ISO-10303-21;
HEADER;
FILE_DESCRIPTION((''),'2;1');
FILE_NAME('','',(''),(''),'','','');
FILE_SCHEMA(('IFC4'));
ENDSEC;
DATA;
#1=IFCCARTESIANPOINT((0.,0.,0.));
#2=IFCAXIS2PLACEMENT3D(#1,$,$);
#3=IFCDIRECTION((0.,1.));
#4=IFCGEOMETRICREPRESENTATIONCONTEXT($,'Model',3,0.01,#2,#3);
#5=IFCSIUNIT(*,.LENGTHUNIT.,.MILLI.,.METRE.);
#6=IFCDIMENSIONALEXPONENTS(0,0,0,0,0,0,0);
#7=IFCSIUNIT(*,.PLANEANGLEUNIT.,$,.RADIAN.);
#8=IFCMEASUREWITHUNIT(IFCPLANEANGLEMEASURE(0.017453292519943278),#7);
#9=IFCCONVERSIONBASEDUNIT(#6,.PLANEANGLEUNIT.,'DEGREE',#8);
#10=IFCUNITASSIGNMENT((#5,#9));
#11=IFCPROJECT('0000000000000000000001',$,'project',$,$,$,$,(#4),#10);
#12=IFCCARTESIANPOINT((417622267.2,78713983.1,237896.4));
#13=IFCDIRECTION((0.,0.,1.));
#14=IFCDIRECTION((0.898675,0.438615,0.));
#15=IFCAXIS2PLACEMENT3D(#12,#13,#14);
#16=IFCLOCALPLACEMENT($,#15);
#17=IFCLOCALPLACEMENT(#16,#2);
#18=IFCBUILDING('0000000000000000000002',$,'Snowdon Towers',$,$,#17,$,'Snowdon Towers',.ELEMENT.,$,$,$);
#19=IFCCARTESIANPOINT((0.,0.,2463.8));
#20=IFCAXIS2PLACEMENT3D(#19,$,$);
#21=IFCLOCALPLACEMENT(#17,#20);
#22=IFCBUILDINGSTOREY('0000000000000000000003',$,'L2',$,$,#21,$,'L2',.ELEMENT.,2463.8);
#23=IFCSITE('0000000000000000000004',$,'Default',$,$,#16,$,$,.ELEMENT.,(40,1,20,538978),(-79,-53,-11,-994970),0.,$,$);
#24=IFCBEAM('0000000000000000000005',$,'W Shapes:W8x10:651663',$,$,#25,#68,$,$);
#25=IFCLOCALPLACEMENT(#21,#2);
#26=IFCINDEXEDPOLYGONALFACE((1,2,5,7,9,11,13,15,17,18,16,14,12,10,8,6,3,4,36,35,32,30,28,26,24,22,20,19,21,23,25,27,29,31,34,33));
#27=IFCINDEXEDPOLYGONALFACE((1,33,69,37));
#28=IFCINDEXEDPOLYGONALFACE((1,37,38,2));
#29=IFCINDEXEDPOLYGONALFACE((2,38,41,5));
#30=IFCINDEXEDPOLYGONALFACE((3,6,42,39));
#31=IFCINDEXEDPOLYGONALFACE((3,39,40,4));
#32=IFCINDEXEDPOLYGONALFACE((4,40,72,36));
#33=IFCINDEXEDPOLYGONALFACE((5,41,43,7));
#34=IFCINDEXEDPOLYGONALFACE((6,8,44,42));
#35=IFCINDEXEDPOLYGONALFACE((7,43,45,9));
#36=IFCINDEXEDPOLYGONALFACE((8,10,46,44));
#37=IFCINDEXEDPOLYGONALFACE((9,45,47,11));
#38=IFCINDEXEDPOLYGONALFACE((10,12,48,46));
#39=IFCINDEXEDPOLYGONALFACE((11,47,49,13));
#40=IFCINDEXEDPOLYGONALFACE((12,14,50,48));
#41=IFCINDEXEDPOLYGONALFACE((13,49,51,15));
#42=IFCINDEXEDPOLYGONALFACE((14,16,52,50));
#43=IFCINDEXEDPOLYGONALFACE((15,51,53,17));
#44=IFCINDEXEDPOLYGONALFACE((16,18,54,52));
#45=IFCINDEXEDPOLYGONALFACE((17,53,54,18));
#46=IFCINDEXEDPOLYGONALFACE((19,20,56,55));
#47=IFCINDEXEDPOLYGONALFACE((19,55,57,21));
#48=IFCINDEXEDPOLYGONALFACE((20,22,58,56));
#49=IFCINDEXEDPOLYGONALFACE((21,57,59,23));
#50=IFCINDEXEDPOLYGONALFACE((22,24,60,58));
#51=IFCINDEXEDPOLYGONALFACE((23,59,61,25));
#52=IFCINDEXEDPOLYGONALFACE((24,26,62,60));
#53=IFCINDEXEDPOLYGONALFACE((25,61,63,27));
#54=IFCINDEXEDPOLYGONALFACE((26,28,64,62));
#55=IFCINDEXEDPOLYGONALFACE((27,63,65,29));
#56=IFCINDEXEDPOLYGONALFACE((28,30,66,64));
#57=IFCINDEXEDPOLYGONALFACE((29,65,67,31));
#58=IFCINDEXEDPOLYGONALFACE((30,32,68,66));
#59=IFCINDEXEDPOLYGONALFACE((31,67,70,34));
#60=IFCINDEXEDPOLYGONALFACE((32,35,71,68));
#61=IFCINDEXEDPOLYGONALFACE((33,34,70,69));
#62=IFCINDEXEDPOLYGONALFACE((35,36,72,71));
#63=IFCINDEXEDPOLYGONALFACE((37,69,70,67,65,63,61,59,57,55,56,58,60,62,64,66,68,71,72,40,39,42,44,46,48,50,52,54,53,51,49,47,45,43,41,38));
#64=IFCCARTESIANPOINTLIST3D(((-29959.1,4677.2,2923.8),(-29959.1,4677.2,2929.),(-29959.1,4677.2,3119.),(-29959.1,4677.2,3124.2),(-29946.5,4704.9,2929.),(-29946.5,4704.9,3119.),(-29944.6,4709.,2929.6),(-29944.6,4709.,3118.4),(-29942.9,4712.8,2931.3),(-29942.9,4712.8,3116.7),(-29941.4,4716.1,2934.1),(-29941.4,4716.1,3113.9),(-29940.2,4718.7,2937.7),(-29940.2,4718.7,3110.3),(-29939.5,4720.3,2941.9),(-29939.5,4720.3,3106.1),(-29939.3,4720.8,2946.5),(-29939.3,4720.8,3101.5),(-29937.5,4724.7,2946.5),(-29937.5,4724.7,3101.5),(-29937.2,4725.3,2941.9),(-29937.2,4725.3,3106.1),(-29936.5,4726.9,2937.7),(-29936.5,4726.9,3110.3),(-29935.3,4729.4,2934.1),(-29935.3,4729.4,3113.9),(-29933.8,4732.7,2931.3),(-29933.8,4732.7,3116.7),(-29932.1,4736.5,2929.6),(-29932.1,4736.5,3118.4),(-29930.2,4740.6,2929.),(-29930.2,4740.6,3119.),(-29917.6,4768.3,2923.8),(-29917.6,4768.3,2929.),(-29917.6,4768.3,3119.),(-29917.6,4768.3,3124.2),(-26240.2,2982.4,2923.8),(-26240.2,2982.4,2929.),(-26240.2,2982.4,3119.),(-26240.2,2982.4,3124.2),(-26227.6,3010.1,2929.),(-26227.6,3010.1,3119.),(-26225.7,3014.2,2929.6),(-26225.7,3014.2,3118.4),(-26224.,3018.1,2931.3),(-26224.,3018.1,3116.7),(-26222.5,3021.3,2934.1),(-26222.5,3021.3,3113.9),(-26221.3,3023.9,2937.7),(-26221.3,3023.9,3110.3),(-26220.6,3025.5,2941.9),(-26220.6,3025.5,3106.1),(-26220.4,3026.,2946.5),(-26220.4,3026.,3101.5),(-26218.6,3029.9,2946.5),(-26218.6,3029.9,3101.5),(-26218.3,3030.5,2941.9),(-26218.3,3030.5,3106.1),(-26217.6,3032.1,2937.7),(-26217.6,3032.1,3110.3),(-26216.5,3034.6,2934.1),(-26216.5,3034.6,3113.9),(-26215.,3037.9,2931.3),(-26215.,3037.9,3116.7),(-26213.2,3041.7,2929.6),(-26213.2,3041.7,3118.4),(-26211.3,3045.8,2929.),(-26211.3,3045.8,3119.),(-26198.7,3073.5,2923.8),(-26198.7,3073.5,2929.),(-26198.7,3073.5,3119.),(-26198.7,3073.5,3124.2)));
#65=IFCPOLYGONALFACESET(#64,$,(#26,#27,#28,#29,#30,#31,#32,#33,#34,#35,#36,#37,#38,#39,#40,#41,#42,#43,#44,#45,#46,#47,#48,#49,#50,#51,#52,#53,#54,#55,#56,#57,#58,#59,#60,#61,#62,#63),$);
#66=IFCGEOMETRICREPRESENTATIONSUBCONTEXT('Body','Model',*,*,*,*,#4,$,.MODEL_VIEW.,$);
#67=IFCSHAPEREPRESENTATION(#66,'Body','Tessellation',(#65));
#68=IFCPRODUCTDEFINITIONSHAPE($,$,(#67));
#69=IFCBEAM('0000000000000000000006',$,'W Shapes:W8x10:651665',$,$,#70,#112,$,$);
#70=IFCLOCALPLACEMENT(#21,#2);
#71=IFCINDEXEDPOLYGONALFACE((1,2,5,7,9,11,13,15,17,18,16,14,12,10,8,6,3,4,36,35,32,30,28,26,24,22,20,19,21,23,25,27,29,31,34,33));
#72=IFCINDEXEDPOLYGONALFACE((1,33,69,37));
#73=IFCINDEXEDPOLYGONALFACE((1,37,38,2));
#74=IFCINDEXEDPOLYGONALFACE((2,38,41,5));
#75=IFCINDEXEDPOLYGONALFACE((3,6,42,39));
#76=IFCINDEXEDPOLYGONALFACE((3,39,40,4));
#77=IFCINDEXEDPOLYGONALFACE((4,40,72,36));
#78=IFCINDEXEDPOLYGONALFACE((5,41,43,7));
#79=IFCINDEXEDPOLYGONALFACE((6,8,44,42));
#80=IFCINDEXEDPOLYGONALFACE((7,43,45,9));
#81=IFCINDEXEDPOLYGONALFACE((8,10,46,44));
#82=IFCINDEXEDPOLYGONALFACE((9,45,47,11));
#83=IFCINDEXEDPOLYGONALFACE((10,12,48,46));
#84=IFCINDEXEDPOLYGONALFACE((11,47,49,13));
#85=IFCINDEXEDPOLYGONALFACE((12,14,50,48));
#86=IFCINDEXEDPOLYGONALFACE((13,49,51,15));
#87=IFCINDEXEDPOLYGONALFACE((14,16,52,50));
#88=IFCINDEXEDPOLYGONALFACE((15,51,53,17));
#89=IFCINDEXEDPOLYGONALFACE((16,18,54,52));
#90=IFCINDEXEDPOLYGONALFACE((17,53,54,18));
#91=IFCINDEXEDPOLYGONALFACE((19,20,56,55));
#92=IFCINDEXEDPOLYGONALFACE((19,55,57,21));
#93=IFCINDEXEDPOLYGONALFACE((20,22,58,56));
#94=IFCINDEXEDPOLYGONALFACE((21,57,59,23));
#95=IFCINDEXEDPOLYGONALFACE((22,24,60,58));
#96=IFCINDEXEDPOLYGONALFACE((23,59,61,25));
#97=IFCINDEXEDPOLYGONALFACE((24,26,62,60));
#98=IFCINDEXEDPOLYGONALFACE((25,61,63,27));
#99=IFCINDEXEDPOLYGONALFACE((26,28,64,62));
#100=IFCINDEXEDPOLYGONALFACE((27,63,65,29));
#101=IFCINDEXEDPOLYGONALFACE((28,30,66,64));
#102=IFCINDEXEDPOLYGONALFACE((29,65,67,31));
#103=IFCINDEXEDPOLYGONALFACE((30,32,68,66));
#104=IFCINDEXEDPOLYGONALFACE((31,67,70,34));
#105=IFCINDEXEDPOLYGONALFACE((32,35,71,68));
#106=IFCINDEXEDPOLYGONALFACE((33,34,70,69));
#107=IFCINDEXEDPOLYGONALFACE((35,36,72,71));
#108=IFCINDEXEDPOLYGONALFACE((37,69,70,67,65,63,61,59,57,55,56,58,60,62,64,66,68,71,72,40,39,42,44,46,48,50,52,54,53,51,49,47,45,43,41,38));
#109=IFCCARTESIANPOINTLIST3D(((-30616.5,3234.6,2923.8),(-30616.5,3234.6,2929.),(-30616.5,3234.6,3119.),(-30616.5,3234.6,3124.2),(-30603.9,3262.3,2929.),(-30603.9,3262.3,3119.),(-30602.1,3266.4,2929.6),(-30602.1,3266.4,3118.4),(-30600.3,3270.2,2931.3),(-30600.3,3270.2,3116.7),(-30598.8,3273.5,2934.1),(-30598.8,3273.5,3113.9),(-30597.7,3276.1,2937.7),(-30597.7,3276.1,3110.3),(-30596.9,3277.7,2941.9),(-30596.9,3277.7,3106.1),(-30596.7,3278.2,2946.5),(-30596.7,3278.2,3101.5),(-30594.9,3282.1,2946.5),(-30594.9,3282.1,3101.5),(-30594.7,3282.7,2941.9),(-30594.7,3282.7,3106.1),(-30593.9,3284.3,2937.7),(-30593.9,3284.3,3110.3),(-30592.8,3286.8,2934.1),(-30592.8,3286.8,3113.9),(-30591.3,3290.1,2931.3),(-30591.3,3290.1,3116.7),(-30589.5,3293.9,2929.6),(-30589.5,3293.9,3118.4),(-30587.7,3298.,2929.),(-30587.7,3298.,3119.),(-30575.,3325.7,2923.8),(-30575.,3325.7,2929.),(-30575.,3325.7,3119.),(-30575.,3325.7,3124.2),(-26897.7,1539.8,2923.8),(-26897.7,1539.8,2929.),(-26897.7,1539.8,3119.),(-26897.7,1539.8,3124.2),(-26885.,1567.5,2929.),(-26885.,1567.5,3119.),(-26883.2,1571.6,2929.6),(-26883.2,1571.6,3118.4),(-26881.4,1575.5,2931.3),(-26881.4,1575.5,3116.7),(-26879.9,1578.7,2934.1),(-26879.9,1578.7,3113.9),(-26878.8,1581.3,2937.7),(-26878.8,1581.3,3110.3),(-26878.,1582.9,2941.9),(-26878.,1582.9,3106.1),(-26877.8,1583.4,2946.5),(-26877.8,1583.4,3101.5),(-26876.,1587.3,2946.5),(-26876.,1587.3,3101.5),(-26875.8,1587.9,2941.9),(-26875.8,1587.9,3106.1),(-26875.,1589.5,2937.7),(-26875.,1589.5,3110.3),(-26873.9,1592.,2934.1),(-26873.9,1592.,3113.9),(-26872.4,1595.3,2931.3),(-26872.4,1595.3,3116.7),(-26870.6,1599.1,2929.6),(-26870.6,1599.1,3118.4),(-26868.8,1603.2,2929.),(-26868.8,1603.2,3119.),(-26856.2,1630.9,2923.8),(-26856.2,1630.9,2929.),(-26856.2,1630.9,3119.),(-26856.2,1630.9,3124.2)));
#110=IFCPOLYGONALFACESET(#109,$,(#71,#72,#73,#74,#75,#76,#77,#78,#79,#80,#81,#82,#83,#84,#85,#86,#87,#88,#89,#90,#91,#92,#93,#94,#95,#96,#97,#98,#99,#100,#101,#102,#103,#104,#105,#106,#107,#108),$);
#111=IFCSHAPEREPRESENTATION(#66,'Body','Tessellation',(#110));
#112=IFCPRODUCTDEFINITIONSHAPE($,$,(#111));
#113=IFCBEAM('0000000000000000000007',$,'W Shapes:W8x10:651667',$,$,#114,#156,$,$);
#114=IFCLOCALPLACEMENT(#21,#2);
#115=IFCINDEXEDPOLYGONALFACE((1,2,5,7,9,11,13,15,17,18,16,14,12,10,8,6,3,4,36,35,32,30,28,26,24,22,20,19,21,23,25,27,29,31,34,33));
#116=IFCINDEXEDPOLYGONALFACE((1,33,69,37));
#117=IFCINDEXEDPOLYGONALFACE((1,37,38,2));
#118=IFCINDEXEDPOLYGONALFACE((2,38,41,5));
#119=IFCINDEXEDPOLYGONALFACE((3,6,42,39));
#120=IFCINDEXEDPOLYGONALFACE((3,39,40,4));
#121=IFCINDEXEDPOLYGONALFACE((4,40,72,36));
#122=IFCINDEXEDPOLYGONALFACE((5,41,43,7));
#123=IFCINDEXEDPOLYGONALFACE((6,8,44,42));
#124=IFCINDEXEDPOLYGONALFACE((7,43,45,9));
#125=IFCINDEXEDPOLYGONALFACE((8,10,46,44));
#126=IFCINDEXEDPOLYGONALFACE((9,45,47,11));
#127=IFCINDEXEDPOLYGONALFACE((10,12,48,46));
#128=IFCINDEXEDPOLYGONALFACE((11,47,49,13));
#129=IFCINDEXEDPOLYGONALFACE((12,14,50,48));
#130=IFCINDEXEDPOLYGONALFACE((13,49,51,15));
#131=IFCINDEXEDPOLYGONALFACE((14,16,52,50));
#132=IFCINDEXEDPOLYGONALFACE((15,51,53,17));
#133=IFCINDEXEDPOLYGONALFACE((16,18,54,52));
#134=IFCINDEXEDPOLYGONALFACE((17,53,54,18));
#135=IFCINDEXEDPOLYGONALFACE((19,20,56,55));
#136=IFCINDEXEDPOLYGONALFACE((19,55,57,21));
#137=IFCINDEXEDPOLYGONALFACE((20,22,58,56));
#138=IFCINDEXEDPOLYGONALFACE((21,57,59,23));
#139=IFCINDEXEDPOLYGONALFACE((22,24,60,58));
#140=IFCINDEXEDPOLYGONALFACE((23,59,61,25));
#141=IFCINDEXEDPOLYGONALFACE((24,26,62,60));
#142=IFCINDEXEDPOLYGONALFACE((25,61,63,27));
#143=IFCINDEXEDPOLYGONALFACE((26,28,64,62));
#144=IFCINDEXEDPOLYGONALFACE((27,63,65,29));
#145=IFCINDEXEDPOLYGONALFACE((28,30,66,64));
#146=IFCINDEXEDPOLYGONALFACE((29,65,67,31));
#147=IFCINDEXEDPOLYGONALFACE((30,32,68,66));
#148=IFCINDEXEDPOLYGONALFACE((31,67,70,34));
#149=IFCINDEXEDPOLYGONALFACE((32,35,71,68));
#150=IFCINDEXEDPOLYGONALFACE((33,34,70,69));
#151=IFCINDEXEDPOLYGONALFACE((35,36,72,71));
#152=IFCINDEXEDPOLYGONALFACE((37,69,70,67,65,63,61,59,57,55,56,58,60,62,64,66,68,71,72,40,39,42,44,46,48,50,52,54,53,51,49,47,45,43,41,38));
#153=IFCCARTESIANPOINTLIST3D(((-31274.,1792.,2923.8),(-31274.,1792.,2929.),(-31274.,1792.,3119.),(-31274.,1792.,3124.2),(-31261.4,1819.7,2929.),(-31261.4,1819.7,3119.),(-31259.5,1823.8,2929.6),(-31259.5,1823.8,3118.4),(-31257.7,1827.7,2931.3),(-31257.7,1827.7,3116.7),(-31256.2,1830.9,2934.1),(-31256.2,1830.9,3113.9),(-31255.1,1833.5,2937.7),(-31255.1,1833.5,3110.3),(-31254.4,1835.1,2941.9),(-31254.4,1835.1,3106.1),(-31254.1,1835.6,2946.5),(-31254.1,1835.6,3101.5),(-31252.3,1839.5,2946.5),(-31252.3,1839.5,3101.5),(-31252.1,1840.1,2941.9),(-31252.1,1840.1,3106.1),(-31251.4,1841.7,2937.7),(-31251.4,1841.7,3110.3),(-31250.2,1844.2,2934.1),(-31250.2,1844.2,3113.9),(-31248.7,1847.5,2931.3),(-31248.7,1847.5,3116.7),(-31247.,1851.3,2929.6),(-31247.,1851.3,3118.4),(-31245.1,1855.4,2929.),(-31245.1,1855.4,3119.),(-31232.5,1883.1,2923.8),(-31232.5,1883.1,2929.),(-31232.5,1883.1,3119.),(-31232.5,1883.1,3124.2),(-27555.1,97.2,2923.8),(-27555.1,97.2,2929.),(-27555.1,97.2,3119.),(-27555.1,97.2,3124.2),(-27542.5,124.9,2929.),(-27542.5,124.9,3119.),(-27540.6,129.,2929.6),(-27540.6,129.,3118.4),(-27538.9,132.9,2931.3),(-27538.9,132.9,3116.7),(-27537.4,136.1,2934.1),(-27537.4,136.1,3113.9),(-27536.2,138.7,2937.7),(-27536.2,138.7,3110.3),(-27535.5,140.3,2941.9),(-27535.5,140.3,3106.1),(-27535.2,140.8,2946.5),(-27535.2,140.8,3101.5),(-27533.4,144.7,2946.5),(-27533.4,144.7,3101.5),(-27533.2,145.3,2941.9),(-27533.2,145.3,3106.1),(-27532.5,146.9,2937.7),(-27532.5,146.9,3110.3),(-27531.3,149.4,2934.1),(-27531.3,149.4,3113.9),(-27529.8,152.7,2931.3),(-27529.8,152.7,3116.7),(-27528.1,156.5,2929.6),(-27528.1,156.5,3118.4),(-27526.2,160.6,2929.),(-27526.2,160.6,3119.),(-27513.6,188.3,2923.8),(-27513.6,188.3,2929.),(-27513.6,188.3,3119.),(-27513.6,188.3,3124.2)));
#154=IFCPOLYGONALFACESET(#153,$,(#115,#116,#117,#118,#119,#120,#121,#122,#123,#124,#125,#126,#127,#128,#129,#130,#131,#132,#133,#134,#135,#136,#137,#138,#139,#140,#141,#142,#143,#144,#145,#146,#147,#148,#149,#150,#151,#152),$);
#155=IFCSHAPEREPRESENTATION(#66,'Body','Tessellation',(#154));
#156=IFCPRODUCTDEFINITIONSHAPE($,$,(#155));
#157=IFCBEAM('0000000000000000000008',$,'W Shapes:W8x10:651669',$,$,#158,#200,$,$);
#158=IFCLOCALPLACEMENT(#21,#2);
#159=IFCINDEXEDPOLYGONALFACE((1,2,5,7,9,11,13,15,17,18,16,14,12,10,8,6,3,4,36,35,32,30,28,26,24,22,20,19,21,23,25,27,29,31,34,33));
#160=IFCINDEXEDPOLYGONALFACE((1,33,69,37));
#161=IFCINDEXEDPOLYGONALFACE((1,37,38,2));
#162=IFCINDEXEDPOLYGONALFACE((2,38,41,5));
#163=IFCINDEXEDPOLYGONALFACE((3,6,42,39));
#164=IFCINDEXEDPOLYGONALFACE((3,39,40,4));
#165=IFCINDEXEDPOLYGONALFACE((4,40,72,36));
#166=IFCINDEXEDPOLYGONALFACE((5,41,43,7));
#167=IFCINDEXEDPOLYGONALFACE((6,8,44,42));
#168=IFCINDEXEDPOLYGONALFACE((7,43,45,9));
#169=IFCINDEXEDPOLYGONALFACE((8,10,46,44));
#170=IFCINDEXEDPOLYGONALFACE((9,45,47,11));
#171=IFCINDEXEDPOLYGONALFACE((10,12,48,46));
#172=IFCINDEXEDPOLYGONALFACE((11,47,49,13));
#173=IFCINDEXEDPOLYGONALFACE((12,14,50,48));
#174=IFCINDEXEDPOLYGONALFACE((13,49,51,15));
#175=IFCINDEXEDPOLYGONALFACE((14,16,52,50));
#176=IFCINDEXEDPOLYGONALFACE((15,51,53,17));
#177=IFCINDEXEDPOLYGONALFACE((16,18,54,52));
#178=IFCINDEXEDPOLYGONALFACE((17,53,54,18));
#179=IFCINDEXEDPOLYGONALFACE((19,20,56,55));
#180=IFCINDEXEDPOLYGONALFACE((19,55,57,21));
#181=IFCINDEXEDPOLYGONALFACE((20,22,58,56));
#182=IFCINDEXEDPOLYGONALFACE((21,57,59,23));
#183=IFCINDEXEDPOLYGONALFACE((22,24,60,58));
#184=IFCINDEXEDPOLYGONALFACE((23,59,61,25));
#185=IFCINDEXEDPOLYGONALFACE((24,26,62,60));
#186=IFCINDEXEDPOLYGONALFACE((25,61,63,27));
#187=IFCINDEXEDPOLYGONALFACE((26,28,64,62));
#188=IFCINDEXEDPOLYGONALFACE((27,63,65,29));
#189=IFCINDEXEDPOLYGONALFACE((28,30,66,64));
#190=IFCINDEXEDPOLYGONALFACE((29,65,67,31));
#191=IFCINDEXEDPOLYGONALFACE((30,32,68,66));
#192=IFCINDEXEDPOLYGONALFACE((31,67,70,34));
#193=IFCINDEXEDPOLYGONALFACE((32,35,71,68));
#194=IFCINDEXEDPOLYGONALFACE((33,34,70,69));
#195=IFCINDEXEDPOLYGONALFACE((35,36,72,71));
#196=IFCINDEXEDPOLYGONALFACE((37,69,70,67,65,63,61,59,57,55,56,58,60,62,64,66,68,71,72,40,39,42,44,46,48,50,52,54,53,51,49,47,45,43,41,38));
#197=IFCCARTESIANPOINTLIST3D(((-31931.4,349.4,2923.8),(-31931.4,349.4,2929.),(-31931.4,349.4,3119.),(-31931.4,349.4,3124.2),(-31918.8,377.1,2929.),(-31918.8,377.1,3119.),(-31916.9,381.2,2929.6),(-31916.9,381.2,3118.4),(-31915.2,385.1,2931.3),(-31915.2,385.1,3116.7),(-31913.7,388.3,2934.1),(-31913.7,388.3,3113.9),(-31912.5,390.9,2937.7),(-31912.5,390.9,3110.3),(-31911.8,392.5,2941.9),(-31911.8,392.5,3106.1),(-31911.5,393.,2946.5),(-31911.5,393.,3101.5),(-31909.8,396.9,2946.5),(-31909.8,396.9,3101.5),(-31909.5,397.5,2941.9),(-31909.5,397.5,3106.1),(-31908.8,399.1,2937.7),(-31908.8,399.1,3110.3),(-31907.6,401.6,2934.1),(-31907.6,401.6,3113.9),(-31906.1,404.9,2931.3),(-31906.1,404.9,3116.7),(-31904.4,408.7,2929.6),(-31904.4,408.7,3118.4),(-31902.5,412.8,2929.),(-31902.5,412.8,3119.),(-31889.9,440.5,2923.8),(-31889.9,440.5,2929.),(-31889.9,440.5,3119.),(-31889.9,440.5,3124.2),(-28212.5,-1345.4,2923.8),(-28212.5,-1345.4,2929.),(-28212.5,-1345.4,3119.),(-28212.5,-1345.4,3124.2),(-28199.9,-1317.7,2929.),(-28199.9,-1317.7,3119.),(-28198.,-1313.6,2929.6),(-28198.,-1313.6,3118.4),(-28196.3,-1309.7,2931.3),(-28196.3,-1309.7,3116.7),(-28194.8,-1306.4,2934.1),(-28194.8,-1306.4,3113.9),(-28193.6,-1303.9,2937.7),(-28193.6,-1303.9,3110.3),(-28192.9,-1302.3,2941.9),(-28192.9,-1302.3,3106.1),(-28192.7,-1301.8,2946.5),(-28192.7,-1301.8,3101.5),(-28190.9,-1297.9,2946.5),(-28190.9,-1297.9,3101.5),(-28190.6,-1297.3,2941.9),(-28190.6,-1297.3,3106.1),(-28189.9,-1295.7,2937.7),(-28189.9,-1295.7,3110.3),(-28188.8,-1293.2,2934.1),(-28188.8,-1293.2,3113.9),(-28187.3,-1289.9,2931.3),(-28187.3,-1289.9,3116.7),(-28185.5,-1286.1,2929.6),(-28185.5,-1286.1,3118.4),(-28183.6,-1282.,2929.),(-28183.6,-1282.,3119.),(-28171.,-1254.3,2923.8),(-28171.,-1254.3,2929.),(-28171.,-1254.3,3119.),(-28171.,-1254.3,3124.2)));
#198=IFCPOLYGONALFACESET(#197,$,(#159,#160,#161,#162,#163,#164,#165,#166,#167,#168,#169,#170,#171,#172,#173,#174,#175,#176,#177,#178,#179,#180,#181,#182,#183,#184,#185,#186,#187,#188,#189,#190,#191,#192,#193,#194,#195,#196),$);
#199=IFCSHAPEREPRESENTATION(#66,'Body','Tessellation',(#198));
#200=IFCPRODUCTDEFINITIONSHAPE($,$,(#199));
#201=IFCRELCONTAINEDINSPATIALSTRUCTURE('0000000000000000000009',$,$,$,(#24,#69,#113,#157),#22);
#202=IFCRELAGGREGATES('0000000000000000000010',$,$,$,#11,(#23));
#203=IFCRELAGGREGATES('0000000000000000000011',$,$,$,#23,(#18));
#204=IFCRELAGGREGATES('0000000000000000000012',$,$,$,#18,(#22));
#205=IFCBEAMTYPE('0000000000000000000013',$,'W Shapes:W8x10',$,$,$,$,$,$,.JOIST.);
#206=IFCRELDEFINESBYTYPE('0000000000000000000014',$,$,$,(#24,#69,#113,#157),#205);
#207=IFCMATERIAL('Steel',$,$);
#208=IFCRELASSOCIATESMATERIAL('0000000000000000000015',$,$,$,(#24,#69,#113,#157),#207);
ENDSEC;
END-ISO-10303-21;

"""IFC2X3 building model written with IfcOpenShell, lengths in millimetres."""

from ifc_helpers import new_model, entity, si_unit, converted_unit, direction, frame, frame_2d, origin, place, context, subcontext, project, spatial, i_section, extrude, material, type_object, element, save


model = new_model("IFC2X3")

# Units and contexts
model_context = context("Model", 3, precision=0.01, world=origin(), true_north=direction((0.0, 1.0)))
body_context = subcontext(model_context, "Body", "Model", "MODEL_VIEW")
ifc_project = project(units=[si_unit("LENGTHUNIT", "METRE", prefix="MILLI"), converted_unit("PLANEANGLEUNIT", "DEGREE", entity("IfcPlaneAngleMeasure", 0.017453292519943278), si_unit("PLANEANGLEUNIT", "RADIAN"), dimensions=[0, 0, 0, 0, 0, 0, 0])], contexts=[model_context])

# Site, building, storey
site_placement = place(None, frame((417622267.2, 78713983.1, 237896.4), z_axis=(0.0, 0.0, 1.0), x_axis=(0.898675, 0.438615, 0.0)))
site = spatial("IfcSite", under=ifc_project, at=site_placement, Name="Default", CompositionType="ELEMENT", RefLatitude=(40, 1, 20, 538978), RefLongitude=(-79, -53, -11, -994970), RefElevation=0.0)
building_placement = place(site_placement, origin())
building = spatial("IfcBuilding", under=site, at=building_placement, Name="Snowdon Towers", LongName="Snowdon Towers", CompositionType="ELEMENT")
storey_placement = place(building_placement, frame((0.0, 0.0, 2463.8)))
storey = spatial("IfcBuildingStorey", under=building, at=storey_placement, Name="L2", LongName="L2", CompositionType="ELEMENT", Elevation=2463.8)

# Beams
ifc_material = material(Name="Steel")
beam_type_1 = type_object("IfcBeamType", Name="W Shapes:W8x10", PredefinedType="JOIST")
beam_1_placement = place(storey_placement, frame((-30066.6, 4781.2, 3124.2), z_axis=(0.0, 0.0, 1.0), x_axis=(0.909961, -0.414693, 0.0)))
element("IfcBeam", 1, at=beam_1_placement, inside=storey, type_object=beam_type_1, material=ifc_material, Name="W Shapes:W8x10:651663", context=body_context, shape_type="SweptSolid", body=[
    extrude(i_section(OverallWidth=100.1, OverallDepth=200.4, WebThickness=4.3, FlangeThickness=5.2, FilletRadius=17.5, at=frame_2d((0.0, 0.0), x_axis=(0.0, 1.0))), frame((141.0, 0.0, -100.2), z_axis=(1.0, 0.0, 0.0), x_axis=(0.0, 0.0, -1.0)), (0.0, 0.0, 1.0), 4086.9),
])
beam_2_placement = place(storey_placement, frame((-30724.1, 3338.6, 3124.2), z_axis=(0.0, 0.0, 1.0), x_axis=(0.909961, -0.414693, 0.0)))
element("IfcBeam", 2, at=beam_2_placement, inside=storey, type_object=beam_type_1, material=ifc_material, Name="W Shapes:W8x10:651665", context=body_context, shape_type="SweptSolid", body=[
    extrude(i_section(OverallWidth=100.1, OverallDepth=200.4, WebThickness=4.3, FlangeThickness=5.2, FilletRadius=17.5, at=frame_2d((0.0, 0.0), x_axis=(0.0, 1.0))), frame((141.0, 0.0, -100.2), z_axis=(1.0, 0.0, 0.0), x_axis=(0.0, 0.0, -1.0)), (0.0, 0.0, 1.0), 4086.9),
])
beam_3_placement = place(storey_placement, frame((-31381.5, 1896.0, 3124.2), z_axis=(0.0, 0.0, 1.0), x_axis=(0.909961, -0.414693, 0.0)))
element("IfcBeam", 3, at=beam_3_placement, inside=storey, type_object=beam_type_1, material=ifc_material, Name="W Shapes:W8x10:651667", context=body_context, shape_type="SweptSolid", body=[
    extrude(i_section(OverallWidth=100.1, OverallDepth=200.4, WebThickness=4.3, FlangeThickness=5.2, FilletRadius=17.5, at=frame_2d((0.0, 0.0), x_axis=(0.0, 1.0))), frame((141.0, 0.0, -100.2), z_axis=(1.0, 0.0, 0.0), x_axis=(0.0, 0.0, -1.0)), (0.0, 0.0, 1.0), 4086.9),
])
beam_4_placement = place(storey_placement, frame((-32038.9, 453.4, 3124.2), z_axis=(0.0, 0.0, 1.0), x_axis=(0.909961, -0.414693, 0.0)))
element("IfcBeam", 4, at=beam_4_placement, inside=storey, type_object=beam_type_1, material=ifc_material, Name="W Shapes:W8x10:651669", context=body_context, shape_type="SweptSolid", body=[
    extrude(i_section(OverallWidth=100.1, OverallDepth=200.4, WebThickness=4.3, FlangeThickness=5.2, FilletRadius=17.5, at=frame_2d((0.0, 0.0), x_axis=(0.0, 1.0))), frame((141.0, 0.0, -100.2), z_axis=(1.0, 0.0, 0.0), x_axis=(0.0, 0.0, -1.0)), (0.0, 0.0, 1.0), 4086.9),
])

save(model, "model.ifc")
